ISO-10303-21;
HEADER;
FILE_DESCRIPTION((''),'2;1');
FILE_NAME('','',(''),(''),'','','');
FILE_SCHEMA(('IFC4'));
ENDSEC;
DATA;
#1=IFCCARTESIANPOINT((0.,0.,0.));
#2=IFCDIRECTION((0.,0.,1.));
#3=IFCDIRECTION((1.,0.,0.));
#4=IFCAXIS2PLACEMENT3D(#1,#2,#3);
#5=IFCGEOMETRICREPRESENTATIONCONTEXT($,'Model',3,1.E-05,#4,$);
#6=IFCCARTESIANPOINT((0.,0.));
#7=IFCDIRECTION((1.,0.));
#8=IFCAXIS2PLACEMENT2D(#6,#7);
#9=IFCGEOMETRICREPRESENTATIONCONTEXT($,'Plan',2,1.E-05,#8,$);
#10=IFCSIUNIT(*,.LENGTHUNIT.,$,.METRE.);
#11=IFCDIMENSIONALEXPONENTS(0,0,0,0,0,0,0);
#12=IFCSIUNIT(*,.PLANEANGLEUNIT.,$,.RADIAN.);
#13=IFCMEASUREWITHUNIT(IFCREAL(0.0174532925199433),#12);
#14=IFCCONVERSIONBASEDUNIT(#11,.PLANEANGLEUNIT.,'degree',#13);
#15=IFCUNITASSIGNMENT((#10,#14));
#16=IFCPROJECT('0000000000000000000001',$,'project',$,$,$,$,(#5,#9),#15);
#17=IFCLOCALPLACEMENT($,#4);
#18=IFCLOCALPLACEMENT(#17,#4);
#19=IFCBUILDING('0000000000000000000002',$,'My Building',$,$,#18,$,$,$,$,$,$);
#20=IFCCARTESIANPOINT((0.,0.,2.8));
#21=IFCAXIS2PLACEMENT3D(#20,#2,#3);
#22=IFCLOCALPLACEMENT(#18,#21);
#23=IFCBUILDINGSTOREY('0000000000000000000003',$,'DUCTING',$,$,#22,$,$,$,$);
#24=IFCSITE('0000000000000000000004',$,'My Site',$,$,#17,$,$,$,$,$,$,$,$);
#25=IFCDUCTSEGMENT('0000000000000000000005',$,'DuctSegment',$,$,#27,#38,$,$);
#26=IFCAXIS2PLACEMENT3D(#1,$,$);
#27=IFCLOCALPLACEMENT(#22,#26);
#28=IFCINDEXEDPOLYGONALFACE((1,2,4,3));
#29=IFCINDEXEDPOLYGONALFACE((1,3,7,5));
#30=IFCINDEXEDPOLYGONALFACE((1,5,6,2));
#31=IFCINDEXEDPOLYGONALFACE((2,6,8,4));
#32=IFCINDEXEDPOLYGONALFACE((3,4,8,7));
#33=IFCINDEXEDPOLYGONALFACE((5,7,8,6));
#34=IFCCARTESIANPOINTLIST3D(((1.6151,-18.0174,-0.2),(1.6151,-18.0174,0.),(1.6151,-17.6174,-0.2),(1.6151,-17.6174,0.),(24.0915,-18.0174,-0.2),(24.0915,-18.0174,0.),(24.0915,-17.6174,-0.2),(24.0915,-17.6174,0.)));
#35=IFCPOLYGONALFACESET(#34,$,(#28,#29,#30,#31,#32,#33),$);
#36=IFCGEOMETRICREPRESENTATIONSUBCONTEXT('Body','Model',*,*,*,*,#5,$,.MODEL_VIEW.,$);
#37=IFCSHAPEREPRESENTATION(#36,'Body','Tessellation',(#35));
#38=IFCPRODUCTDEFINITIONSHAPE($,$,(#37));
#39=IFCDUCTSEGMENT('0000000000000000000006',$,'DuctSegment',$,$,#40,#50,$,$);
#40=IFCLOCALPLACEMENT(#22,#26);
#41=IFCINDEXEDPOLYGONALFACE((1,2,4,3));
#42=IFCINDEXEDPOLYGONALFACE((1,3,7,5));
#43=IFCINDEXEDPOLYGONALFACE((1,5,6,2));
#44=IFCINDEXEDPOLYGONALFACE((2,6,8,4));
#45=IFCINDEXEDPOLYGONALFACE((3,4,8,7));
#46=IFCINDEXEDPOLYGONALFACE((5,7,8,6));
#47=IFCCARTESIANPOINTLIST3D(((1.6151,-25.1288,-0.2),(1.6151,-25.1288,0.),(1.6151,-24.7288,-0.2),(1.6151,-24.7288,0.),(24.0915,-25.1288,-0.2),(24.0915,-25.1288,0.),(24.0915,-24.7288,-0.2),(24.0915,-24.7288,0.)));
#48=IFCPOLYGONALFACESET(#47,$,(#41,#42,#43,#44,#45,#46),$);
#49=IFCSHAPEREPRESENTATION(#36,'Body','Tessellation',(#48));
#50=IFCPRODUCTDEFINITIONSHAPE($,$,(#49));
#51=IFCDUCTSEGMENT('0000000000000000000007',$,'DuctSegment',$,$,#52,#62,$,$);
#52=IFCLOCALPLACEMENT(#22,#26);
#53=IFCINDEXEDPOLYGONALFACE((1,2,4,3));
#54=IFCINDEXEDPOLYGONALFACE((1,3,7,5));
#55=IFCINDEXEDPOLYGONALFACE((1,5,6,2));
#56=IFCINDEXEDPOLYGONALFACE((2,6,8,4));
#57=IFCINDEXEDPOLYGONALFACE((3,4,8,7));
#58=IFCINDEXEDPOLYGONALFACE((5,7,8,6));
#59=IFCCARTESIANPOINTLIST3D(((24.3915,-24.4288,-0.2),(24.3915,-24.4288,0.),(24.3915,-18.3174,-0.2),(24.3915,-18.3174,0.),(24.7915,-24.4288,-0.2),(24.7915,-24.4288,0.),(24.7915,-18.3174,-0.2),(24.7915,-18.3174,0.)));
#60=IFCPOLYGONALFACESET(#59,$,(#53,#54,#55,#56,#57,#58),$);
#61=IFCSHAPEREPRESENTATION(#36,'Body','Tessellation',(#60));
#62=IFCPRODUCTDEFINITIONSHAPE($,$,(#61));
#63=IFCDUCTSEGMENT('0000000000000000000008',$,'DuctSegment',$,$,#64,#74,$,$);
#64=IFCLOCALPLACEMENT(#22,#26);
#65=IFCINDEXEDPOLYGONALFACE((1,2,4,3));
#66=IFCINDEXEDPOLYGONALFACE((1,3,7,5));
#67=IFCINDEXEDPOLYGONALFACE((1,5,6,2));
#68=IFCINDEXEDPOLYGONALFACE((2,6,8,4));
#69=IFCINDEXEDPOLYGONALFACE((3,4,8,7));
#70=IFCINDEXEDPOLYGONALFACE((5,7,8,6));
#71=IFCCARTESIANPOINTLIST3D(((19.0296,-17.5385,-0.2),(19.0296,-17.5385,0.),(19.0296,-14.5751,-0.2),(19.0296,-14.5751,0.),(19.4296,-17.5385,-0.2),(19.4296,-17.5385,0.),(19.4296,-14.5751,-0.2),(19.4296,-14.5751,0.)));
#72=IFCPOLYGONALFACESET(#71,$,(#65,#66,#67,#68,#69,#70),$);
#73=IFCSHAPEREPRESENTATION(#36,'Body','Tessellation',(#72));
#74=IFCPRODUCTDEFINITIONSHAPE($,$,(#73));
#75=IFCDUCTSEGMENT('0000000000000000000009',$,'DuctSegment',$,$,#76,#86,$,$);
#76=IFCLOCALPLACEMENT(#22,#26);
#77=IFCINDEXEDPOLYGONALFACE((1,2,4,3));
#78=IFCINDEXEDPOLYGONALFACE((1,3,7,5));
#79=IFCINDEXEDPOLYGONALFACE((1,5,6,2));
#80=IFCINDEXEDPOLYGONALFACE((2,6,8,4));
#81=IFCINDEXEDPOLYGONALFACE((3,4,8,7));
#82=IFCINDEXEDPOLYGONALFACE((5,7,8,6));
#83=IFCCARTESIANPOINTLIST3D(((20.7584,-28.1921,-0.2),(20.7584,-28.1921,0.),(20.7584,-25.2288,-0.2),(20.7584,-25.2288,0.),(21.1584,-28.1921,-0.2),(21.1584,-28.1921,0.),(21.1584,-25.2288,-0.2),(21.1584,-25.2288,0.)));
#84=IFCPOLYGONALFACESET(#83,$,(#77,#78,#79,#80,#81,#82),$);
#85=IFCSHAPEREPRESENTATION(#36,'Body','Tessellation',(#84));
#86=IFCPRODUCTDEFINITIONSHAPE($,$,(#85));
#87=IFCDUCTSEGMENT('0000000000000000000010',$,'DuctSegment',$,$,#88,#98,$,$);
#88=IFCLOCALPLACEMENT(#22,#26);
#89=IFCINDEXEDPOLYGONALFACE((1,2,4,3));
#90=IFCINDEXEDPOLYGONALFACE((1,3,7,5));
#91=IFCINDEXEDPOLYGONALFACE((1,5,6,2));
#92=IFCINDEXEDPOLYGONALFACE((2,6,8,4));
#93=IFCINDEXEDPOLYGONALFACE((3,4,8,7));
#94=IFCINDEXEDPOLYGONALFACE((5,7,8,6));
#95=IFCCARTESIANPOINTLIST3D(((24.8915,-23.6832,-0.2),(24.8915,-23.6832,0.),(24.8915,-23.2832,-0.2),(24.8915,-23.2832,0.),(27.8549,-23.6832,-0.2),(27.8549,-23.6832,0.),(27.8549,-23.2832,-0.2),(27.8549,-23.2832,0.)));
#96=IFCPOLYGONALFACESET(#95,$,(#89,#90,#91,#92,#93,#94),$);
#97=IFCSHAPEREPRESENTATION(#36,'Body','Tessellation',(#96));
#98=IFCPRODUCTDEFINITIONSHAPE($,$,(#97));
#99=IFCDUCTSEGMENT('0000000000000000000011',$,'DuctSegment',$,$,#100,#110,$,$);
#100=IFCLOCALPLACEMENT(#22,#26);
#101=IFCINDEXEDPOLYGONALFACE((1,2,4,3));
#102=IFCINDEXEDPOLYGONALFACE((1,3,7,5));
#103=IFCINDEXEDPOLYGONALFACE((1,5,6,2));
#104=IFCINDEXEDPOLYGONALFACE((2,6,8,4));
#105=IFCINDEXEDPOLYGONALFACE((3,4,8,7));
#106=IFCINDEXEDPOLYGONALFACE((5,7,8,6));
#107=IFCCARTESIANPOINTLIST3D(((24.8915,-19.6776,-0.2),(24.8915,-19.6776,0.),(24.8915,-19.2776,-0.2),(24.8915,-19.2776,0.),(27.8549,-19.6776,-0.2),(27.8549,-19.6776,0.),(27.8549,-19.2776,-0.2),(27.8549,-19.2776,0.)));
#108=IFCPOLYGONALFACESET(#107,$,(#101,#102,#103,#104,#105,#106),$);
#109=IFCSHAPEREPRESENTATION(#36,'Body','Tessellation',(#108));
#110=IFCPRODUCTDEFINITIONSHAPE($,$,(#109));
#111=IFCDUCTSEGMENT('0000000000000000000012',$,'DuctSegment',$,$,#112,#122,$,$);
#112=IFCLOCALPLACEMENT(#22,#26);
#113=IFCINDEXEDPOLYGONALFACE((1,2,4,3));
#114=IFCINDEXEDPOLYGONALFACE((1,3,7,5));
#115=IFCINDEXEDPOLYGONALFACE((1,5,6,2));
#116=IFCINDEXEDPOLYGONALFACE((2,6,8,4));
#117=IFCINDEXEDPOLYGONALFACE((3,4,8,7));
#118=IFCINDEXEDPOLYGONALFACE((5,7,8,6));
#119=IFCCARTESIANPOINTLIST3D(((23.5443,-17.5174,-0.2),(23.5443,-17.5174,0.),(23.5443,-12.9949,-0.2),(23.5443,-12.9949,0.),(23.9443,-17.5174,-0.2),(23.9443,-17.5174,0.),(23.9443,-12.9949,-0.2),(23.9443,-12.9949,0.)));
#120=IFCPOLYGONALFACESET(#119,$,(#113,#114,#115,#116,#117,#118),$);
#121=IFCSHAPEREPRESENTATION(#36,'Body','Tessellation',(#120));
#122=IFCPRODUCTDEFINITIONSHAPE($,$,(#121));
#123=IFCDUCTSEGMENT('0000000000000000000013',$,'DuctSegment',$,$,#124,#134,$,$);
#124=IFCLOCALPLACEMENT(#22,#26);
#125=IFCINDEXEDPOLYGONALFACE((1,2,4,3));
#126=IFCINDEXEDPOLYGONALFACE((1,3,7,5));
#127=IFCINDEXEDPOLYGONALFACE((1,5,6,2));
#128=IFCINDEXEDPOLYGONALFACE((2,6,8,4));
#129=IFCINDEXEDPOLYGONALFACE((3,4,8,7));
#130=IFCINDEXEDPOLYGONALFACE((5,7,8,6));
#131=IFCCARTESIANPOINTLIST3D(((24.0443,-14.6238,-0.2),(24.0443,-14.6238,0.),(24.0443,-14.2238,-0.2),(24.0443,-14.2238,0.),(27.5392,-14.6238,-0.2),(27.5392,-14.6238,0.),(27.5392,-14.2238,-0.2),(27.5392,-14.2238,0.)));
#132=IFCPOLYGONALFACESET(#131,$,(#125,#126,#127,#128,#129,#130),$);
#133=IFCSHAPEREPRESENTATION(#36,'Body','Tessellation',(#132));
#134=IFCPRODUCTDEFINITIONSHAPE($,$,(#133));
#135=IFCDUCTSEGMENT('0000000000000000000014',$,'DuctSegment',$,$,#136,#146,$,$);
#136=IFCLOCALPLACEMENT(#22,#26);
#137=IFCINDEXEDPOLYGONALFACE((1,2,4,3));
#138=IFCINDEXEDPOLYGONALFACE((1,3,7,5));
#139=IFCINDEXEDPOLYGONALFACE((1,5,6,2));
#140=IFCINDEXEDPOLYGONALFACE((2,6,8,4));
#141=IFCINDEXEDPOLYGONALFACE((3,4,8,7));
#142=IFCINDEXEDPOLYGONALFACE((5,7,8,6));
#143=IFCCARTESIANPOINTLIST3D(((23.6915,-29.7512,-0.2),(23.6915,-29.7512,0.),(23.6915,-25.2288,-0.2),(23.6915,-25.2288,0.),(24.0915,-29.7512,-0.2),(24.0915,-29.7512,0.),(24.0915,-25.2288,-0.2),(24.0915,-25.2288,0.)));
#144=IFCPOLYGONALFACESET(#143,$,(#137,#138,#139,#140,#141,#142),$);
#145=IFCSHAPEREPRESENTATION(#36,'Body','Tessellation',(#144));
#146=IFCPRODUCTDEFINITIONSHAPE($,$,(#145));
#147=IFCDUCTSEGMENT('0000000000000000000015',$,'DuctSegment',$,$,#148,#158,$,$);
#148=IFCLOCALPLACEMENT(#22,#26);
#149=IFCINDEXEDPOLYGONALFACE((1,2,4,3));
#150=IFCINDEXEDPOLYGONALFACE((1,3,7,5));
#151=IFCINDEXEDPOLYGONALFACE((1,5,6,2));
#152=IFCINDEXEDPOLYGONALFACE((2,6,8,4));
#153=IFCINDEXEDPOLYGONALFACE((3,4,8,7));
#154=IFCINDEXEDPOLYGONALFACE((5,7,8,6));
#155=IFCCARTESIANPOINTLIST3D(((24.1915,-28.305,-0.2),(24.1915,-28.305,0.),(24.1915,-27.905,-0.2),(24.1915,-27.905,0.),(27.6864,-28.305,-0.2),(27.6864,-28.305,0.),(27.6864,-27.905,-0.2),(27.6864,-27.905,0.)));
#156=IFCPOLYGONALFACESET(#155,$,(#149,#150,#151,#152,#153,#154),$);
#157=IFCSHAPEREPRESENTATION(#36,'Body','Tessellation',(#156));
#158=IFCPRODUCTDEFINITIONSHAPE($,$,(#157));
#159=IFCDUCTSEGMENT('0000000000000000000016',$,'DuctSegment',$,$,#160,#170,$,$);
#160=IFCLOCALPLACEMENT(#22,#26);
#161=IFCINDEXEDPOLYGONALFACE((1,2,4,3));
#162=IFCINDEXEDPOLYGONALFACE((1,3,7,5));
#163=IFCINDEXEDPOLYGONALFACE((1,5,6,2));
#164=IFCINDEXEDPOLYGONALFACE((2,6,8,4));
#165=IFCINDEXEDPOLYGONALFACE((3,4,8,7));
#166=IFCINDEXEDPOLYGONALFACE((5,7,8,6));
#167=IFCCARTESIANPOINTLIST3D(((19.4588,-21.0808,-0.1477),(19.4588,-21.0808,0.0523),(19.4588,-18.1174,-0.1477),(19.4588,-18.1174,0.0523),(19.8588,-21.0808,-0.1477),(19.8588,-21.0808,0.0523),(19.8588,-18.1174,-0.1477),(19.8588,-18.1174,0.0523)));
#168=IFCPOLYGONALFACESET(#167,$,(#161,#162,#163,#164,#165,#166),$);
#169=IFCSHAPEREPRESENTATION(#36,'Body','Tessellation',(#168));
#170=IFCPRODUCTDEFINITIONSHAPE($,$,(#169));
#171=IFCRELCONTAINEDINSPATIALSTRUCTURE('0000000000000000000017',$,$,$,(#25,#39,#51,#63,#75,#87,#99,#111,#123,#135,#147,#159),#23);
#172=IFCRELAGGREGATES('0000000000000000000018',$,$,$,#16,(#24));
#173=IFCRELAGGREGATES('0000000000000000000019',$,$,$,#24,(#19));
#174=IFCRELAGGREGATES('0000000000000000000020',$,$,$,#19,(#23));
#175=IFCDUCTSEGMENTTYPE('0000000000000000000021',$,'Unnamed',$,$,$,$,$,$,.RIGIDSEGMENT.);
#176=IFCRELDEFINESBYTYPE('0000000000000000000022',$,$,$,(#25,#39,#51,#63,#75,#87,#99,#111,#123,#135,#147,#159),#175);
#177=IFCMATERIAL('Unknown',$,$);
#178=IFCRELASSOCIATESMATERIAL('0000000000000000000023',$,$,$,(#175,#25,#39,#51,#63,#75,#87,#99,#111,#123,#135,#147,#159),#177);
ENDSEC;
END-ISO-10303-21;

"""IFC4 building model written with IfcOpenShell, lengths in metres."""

from ifc_helpers import new_model, entity, si_unit, converted_unit, frame, origin_with_axes, origin_2d_with_axis, place, context, subcontext, project, spatial, rectangle, extrude, material, material_profile, profile_set, profile_usage, type_object, element, save


model = new_model("IFC4")

# Units and contexts
model_context = context("Model", 3, precision=1e-05, world=origin_with_axes())
plan_context = context("Plan", 2, precision=1e-05, world=origin_2d_with_axis())
body_context = subcontext(model_context, "Body", "Model", "MODEL_VIEW")
ifc_project = project(units=[si_unit("LENGTHUNIT", "METRE"), converted_unit("PLANEANGLEUNIT", "degree", entity("IfcReal", 0.0174532925199433), si_unit("PLANEANGLEUNIT", "RADIAN"), dimensions=[0, 0, 0, 0, 0, 0, 0])], contexts=[model_context, plan_context])

# Site, building, storey
site_placement = place(None, origin_with_axes())
site = spatial("IfcSite", under=ifc_project, at=site_placement, Name="My Site")
building_placement = place(site_placement, origin_with_axes())
building = spatial("IfcBuilding", under=site, at=building_placement, Name="My Building")
storey_placement = place(building_placement, frame((0.0, 0.0, 2.8), z_axis=(0.0, 0.0, 1.0), x_axis=(1.0, 0.0, 0.0)))
storey = spatial("IfcBuildingStorey", under=building, at=storey_placement, Name="DUCTING")

# Duct segments
ifc_material = material(Name="Unknown")
ifc_material_profile_1 = material_profile(ifc_material, rectangle(XDim=0.4, YDim=0.2))
ifc_profile_set_1 = profile_set([ifc_material_profile_1])
ifc_profile_usage_1 = profile_usage(ifc_profile_set_1, cardinal=5)
duct_segment_type = type_object("IfcDuctSegmentType", Name="Unnamed", PredefinedType="RIGIDSEGMENT", material=ifc_profile_set_1)
duct_segment_1_placement = place(storey_placement, frame((24.0915, -17.8174, -0.1), z_axis=(-1.0, 0.0, 0.0), x_axis=(0.0, -1.0, 0.0)))
element("IfcDuctSegment", 1, at=duct_segment_1_placement, inside=storey, type_object=duct_segment_type, material=ifc_profile_usage_1, Name="DuctSegment", context=body_context, shape_type="SweptSolid", body=[
    extrude(rectangle(XDim=0.4, YDim=0.2), origin_with_axes(), (0.0, 0.0, 1.0), 22.4765),
])
ifc_profile_usage_2 = profile_usage(ifc_profile_set_1, cardinal=5)
duct_segment_2_placement = place(storey_placement, frame((24.0915, -24.9288, -0.1), z_axis=(-1.0, 0.0, 0.0), x_axis=(0.0, -1.0, 0.0)))
element("IfcDuctSegment", 2, at=duct_segment_2_placement, inside=storey, type_object=duct_segment_type, material=ifc_profile_usage_2, Name="DuctSegment", context=body_context, shape_type="SweptSolid", body=[
    extrude(rectangle(XDim=0.4, YDim=0.2), origin_with_axes(), (0.0, 0.0, 1.0), 22.4765),
])
ifc_profile_usage_3 = profile_usage(ifc_profile_set_1, cardinal=5)
duct_segment_3_placement = place(storey_placement, frame((24.5915, -24.4288, -0.1), z_axis=(0.0, 1.0, 0.0), x_axis=(-1.0, 0.0, 0.0)))
element("IfcDuctSegment", 3, at=duct_segment_3_placement, inside=storey, type_object=duct_segment_type, material=ifc_profile_usage_3, Name="DuctSegment", context=body_context, shape_type="SweptSolid", body=[
    extrude(rectangle(XDim=0.4, YDim=0.2), origin_with_axes(), (0.0, 0.0, 1.0), 6.1113),
])
ifc_profile_usage_4 = profile_usage(ifc_profile_set_1, cardinal=5)
duct_segment_4_placement = place(storey_placement, frame((19.2296, -14.5751, -0.1), z_axis=(0.0, -1.0, 0.0), x_axis=(1.0, 0.0, 0.0)))
element("IfcDuctSegment", 4, at=duct_segment_4_placement, inside=storey, type_object=duct_segment_type, material=ifc_profile_usage_4, Name="DuctSegment", context=body_context, shape_type="SweptSolid", body=[
    extrude(rectangle(XDim=0.4, YDim=0.2), origin_with_axes(), (0.0, 0.0, 1.0), 2.9634),
])
ifc_profile_usage_5 = profile_usage(ifc_profile_set_1, cardinal=5)
duct_segment_5_placement = place(storey_placement, frame((20.9584, -28.1921, -0.1), z_axis=(0.0, 1.0, 0.0), x_axis=(-1.0, 0.0, 0.0)))
element("IfcDuctSegment", 5, at=duct_segment_5_placement, inside=storey, type_object=duct_segment_type, material=ifc_profile_usage_5, Name="DuctSegment", context=body_context, shape_type="SweptSolid", body=[
    extrude(rectangle(XDim=0.4, YDim=0.2), origin_with_axes(), (0.0, 0.0, 1.0), 2.9634),
])
ifc_profile_usage_6 = profile_usage(ifc_profile_set_1, cardinal=5)
duct_segment_6_placement = place(storey_placement, frame((27.8549, -23.4832, -0.1), z_axis=(-1.0, 0.0, 0.0), x_axis=(0.0, -1.0, 0.0)))
element("IfcDuctSegment", 6, at=duct_segment_6_placement, inside=storey, type_object=duct_segment_type, material=ifc_profile_usage_6, Name="DuctSegment", context=body_context, shape_type="SweptSolid", body=[
    extrude(rectangle(XDim=0.4, YDim=0.2), origin_with_axes(), (0.0, 0.0, 1.0), 2.9634),
])
ifc_profile_usage_7 = profile_usage(ifc_profile_set_1, cardinal=5)
duct_segment_7_placement = place(storey_placement, frame((27.8549, -19.4776, -0.1), z_axis=(-1.0, 0.0, 0.0), x_axis=(0.0, -1.0, 0.0)))
element("IfcDuctSegment", 7, at=duct_segment_7_placement, inside=storey, type_object=duct_segment_type, material=ifc_profile_usage_7, Name="DuctSegment", context=body_context, shape_type="SweptSolid", body=[
    extrude(rectangle(XDim=0.4, YDim=0.2), origin_with_axes(), (0.0, 0.0, 1.0), 2.9634),
])
ifc_profile_usage_8 = profile_usage(ifc_profile_set_1, cardinal=5)
duct_segment_8_placement = place(storey_placement, frame((23.7443, -12.9949, -0.1), z_axis=(0.0, -1.0, 0.0), x_axis=(1.0, 0.0, 0.0)))
element("IfcDuctSegment", 8, at=duct_segment_8_placement, inside=storey, type_object=duct_segment_type, material=ifc_profile_usage_8, Name="DuctSegment", context=body_context, shape_type="SweptSolid", body=[
    extrude(rectangle(XDim=0.4, YDim=0.2), origin_with_axes(), (0.0, 0.0, 1.0), 4.5225),
])
ifc_profile_usage_9 = profile_usage(ifc_profile_set_1, cardinal=5)
duct_segment_9_placement = place(storey_placement, frame((27.5392, -14.4238, -0.1), z_axis=(-1.0, 0.0, 0.0), x_axis=(0.0, -1.0, 0.0)))
element("IfcDuctSegment", 9, at=duct_segment_9_placement, inside=storey, type_object=duct_segment_type, material=ifc_profile_usage_9, Name="DuctSegment", context=body_context, shape_type="SweptSolid", body=[
    extrude(rectangle(XDim=0.4, YDim=0.2), origin_with_axes(), (0.0, 0.0, 1.0), 3.4949),
])
ifc_profile_usage_10 = profile_usage(ifc_profile_set_1, cardinal=5)
duct_segment_10_placement = place(storey_placement, frame((23.8915, -29.7512, -0.1), z_axis=(0.0, 1.0, 0.0), x_axis=(-1.0, 0.0, 0.0)))
element("IfcDuctSegment", 10, at=duct_segment_10_placement, inside=storey, type_object=duct_segment_type, material=ifc_profile_usage_10, Name="DuctSegment", context=body_context, shape_type="SweptSolid", body=[
    extrude(rectangle(XDim=0.4, YDim=0.2), origin_with_axes(), (0.0, 0.0, 1.0), 4.5225),
])
ifc_profile_usage_11 = profile_usage(ifc_profile_set_1, cardinal=5)
duct_segment_11_placement = place(storey_placement, frame((27.6864, -28.105, -0.1), z_axis=(-1.0, 0.0, 0.0), x_axis=(0.0, -1.0, 0.0)))
element("IfcDuctSegment", 11, at=duct_segment_11_placement, inside=storey, type_object=duct_segment_type, material=ifc_profile_usage_11, Name="DuctSegment", context=body_context, shape_type="SweptSolid", body=[
    extrude(rectangle(XDim=0.4, YDim=0.2), origin_with_axes(), (0.0, 0.0, 1.0), 3.4949),
])
ifc_profile_usage_12 = profile_usage(ifc_profile_set_1, cardinal=5)
duct_segment_12_placement = place(storey_placement, frame((19.6588, -21.0808, -0.0477), z_axis=(0.0, 1.0, 0.0), x_axis=(-1.0, 0.0, 0.0)))
element("IfcDuctSegment", 12, at=duct_segment_12_placement, inside=storey, type_object=duct_segment_type, material=ifc_profile_usage_12, Name="DuctSegment", context=body_context, shape_type="SweptSolid", body=[
    extrude(rectangle(XDim=0.4, YDim=0.2), origin_with_axes(), (0.0, 0.0, 1.0), 2.9634),
])

save(model, "model.ifc")
